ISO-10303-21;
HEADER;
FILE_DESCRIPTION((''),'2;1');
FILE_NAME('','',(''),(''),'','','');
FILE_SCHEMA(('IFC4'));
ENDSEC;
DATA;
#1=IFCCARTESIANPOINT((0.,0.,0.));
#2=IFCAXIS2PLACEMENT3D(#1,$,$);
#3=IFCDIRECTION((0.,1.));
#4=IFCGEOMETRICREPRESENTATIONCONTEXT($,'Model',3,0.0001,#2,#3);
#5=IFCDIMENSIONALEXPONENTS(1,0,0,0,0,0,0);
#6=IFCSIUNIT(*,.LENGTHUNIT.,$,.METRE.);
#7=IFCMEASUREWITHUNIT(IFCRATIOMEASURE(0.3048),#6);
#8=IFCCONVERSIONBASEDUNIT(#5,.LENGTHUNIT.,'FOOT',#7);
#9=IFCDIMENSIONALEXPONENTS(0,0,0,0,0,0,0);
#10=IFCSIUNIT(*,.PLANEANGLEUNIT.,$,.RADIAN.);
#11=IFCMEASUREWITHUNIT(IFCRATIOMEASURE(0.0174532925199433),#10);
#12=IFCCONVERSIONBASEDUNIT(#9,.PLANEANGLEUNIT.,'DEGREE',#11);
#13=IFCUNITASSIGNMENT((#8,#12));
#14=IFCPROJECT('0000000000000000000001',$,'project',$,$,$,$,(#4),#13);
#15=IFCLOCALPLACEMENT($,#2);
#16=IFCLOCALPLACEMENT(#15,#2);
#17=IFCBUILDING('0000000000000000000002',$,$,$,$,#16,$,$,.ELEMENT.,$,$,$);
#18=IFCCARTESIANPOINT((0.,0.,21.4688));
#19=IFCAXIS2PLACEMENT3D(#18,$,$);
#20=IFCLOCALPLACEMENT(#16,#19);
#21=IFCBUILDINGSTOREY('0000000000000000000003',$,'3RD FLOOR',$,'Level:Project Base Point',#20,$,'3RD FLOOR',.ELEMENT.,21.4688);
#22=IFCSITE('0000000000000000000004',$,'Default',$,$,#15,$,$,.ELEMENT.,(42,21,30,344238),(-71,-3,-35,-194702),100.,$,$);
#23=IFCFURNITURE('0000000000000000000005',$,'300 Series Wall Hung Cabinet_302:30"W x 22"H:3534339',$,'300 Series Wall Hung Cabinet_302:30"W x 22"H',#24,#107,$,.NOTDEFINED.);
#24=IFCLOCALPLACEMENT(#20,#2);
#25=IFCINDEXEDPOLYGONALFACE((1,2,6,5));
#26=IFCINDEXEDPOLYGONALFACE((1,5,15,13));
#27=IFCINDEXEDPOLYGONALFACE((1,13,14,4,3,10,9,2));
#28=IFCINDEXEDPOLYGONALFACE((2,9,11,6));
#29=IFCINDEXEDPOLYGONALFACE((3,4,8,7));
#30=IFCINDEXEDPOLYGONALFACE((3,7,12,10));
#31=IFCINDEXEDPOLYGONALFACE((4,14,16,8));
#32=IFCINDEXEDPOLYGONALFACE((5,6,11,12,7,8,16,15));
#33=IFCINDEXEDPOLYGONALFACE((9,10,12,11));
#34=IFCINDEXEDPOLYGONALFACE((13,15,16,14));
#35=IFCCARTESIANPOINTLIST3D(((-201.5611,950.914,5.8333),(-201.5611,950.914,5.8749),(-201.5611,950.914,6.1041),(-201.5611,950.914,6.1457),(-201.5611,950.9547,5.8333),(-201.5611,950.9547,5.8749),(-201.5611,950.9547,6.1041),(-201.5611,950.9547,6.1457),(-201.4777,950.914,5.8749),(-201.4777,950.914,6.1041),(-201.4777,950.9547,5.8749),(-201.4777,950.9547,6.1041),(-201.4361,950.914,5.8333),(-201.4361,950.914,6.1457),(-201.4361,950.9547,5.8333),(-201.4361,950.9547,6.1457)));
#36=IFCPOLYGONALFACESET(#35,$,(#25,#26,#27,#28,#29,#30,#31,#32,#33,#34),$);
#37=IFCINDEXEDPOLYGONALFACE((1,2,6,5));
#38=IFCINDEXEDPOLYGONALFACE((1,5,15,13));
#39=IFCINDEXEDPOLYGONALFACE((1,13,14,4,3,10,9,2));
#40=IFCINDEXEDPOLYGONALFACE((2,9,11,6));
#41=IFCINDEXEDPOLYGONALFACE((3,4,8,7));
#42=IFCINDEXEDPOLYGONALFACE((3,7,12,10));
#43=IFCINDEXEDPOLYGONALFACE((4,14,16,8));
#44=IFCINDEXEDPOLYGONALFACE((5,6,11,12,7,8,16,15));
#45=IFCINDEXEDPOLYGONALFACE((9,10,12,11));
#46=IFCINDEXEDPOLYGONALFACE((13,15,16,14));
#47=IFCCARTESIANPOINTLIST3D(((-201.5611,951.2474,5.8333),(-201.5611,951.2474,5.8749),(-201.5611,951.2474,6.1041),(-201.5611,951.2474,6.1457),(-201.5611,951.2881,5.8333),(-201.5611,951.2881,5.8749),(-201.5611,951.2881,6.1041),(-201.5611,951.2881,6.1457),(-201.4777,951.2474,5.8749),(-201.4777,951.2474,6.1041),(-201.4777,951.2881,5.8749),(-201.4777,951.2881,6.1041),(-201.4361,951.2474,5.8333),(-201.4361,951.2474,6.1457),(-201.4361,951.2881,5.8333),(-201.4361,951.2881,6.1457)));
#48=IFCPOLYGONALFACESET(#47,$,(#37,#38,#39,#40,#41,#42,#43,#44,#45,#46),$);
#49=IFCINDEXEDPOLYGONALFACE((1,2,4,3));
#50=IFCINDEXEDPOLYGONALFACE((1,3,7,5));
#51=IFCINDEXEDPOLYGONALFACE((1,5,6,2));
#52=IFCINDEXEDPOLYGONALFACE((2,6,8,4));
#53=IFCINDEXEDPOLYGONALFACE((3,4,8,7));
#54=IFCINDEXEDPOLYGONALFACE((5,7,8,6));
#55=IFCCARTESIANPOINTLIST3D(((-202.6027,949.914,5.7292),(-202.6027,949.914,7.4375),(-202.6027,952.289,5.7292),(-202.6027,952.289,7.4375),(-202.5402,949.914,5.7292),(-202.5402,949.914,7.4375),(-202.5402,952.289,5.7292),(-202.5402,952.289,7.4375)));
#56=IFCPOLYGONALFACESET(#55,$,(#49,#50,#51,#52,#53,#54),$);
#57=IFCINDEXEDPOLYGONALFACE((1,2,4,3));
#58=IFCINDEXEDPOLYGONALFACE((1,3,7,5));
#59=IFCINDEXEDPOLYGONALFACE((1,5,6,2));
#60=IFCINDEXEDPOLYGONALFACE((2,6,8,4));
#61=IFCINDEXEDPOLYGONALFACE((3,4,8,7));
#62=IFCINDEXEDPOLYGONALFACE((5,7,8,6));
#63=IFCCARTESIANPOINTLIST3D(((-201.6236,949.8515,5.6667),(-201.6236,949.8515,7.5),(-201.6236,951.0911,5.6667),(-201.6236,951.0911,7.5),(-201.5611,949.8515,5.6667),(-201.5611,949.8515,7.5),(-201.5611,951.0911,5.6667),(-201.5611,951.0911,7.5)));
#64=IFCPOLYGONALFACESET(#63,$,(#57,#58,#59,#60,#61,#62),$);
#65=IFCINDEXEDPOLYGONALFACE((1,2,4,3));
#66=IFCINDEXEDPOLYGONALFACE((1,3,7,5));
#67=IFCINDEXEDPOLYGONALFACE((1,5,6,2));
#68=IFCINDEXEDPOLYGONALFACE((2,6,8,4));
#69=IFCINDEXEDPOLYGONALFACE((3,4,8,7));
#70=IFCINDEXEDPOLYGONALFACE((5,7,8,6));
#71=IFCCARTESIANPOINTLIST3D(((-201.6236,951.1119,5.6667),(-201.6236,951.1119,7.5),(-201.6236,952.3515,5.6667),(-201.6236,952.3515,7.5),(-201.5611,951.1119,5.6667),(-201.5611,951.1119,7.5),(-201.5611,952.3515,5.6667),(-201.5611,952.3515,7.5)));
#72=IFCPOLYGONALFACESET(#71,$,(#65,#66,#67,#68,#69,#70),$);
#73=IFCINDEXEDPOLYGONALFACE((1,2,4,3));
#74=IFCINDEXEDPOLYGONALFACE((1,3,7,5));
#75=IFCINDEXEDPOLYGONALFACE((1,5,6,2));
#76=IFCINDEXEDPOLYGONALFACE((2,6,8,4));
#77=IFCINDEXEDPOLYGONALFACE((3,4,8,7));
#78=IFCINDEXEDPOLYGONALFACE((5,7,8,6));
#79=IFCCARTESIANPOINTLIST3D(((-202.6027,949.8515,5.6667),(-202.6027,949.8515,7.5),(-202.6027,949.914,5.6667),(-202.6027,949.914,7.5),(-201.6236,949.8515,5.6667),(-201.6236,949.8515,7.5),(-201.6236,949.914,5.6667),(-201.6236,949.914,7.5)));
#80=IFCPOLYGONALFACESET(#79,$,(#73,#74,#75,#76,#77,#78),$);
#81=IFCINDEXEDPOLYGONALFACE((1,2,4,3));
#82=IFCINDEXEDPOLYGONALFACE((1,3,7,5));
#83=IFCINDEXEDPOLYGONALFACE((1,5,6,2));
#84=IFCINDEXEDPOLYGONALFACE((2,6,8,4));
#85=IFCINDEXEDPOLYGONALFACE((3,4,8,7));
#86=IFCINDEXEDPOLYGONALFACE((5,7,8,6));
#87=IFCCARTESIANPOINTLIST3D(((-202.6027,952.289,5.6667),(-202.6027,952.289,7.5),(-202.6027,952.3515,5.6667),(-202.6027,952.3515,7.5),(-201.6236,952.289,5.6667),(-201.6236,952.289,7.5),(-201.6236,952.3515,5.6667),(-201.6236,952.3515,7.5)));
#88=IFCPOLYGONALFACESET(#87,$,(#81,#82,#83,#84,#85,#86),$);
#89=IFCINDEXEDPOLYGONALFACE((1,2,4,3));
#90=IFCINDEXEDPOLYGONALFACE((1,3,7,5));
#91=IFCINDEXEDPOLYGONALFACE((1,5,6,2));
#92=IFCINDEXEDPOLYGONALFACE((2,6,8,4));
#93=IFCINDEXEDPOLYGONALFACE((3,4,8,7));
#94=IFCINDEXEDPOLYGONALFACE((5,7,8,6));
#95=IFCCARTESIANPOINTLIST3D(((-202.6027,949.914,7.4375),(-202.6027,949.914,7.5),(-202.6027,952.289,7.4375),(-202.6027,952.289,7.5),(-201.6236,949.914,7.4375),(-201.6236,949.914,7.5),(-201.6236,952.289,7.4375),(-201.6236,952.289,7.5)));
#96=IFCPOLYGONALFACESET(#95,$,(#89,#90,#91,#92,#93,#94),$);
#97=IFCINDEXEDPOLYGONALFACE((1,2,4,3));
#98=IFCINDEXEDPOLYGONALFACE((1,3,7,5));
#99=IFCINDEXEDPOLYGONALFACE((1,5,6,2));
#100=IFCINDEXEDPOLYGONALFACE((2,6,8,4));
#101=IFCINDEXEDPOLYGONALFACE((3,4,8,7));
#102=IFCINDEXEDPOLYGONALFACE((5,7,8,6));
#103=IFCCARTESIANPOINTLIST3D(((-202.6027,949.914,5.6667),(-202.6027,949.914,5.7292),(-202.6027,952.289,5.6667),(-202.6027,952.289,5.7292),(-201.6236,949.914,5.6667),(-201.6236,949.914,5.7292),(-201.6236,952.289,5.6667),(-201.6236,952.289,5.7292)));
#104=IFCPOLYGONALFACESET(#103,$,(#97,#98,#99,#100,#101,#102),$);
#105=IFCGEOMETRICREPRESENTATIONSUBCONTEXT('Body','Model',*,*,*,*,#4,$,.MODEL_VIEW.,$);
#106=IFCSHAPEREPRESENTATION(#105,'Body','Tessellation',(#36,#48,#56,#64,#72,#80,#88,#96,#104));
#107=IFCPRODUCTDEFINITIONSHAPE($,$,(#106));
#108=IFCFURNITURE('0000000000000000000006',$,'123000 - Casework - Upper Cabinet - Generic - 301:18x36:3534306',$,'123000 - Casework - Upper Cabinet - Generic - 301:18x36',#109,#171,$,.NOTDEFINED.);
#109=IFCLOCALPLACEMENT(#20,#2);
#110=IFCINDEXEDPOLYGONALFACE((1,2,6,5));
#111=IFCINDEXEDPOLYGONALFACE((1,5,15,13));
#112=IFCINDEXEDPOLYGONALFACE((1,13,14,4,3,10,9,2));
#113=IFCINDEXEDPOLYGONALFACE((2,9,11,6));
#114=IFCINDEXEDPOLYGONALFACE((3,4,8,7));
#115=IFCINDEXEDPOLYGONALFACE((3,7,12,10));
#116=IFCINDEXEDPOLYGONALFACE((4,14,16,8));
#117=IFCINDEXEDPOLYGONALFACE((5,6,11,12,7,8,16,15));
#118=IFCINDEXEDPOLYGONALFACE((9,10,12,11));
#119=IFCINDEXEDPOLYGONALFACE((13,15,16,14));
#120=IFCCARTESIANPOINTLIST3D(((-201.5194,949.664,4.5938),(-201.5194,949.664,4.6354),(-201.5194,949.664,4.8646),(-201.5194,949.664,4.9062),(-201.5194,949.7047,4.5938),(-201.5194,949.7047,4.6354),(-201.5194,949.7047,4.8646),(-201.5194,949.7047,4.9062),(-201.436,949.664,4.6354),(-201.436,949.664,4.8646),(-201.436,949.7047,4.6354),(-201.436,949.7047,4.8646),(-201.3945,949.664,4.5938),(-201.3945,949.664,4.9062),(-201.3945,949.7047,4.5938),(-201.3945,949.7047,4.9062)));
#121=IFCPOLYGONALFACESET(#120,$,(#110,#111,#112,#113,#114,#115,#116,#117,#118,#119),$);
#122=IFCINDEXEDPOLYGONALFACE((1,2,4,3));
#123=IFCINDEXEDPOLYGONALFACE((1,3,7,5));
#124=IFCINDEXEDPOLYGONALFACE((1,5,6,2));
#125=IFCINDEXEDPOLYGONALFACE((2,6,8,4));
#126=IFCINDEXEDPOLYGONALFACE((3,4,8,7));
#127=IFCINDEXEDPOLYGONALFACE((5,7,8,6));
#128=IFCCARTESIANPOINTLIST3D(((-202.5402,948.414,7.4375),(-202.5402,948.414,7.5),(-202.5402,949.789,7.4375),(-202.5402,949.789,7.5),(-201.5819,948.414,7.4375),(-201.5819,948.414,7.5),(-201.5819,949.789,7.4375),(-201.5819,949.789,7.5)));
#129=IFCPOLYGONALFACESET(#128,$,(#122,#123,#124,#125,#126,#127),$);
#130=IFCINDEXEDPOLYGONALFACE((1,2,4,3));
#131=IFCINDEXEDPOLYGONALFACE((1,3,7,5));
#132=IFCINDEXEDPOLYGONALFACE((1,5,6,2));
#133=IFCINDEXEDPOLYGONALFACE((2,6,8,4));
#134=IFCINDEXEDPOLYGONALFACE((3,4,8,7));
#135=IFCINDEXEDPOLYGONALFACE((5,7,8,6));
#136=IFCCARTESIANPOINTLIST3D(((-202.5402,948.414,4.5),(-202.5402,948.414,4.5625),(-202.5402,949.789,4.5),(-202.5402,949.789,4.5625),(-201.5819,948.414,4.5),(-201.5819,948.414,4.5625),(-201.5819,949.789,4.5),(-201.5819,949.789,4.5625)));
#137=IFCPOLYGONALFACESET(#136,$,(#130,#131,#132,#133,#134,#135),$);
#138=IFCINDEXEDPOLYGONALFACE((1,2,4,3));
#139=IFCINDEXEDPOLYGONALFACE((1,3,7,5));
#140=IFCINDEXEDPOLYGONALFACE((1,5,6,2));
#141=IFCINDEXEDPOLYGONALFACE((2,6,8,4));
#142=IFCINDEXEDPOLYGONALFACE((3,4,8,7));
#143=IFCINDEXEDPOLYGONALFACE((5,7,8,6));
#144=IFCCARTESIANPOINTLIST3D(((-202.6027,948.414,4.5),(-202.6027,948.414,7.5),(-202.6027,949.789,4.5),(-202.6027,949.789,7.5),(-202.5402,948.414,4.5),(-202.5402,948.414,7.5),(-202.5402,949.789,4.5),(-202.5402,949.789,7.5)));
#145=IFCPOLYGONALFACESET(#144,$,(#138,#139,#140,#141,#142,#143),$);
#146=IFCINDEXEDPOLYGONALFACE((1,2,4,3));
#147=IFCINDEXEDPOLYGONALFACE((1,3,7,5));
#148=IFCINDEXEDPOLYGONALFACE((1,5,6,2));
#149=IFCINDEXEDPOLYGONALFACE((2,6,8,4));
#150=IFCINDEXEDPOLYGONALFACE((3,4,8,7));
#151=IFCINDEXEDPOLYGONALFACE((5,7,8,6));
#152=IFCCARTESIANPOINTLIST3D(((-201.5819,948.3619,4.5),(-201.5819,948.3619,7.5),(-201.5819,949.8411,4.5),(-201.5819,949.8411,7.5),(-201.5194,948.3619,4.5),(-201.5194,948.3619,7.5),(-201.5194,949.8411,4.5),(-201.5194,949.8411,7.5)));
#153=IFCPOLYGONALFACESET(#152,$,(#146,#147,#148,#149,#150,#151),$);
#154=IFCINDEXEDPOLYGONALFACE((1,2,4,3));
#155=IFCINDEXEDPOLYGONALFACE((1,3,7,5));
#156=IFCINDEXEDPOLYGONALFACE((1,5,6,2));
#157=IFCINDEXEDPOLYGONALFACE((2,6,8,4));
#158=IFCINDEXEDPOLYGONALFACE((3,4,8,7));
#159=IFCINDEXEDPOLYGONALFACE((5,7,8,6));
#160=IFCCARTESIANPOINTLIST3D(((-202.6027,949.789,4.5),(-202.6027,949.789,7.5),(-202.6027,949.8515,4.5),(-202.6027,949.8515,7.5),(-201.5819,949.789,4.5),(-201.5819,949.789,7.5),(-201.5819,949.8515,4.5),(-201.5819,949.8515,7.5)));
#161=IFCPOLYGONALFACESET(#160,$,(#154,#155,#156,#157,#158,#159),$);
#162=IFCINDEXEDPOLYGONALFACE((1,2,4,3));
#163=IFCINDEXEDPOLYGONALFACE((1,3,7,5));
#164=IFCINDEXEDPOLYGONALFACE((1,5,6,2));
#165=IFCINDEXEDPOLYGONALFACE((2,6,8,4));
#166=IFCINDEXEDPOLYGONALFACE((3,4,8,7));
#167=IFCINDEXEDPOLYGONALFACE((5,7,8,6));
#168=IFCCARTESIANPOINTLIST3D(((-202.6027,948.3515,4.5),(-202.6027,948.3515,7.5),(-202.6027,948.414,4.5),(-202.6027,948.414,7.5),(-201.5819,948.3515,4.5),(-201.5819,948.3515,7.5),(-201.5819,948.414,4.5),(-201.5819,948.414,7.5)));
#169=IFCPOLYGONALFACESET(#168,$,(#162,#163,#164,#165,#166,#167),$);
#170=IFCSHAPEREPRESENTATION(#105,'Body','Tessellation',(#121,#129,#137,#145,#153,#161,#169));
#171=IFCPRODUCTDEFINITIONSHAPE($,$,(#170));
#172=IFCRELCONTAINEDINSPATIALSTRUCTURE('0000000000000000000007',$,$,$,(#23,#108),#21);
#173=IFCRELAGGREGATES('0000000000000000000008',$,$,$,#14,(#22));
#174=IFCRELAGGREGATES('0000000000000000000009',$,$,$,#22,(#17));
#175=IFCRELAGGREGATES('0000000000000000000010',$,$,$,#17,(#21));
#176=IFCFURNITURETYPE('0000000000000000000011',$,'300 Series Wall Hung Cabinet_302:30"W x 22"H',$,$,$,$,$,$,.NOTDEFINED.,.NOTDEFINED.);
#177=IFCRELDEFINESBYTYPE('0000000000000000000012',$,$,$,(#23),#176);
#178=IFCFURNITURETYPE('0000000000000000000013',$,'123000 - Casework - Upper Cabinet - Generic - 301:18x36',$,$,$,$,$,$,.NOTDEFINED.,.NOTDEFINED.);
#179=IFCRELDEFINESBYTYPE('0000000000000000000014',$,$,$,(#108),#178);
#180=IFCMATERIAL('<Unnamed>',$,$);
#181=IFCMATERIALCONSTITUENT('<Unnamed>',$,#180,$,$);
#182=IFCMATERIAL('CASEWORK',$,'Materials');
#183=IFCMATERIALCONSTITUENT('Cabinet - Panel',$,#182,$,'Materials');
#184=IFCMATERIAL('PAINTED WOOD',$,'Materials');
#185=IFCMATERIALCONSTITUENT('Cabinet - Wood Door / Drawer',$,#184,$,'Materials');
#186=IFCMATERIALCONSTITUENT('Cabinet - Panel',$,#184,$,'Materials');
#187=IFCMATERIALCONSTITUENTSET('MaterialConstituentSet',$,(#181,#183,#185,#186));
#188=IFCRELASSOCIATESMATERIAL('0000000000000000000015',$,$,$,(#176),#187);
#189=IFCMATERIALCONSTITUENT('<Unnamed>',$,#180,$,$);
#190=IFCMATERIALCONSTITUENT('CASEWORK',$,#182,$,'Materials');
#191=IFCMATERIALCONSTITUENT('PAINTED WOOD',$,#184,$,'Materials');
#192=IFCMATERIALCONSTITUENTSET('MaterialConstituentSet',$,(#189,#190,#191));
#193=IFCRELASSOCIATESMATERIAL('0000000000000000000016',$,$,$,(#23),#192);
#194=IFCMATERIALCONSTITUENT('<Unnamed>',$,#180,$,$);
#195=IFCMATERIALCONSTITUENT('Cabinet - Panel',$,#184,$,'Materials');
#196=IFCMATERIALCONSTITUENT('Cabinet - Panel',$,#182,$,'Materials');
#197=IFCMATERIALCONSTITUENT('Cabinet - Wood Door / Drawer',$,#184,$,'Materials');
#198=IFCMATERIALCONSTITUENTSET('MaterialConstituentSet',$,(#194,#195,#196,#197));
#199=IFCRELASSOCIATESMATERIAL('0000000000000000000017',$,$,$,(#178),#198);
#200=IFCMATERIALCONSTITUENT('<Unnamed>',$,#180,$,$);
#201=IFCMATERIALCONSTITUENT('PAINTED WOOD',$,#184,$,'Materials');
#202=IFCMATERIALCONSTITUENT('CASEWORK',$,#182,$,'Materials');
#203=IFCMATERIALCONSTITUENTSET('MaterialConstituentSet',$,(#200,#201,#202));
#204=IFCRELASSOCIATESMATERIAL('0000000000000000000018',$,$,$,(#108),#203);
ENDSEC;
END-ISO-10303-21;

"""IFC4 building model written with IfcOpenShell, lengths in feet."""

from ifc_helpers import new_model, entity, si_unit, converted_unit, direction, frame, frame_2d, origin, origin_2d_with_axis, place, context, subcontext, project, spatial, polyline, rectangle, outline, extrude, source, transform, mapped, material, constituent, constituent_set, type_object, type_shapes, element, save


model = new_model("IFC4")

# Units and contexts
model_context = context("Model", 3, precision=0.0001, world=origin(), true_north=direction((0.0, 1.0)))
body_context = subcontext(model_context, "Body", "Model", "MODEL_VIEW")
ifc_project = project(units=[converted_unit("LENGTHUNIT", "FOOT", entity("IfcRatioMeasure", 0.3048), si_unit("LENGTHUNIT", "METRE"), dimensions=[1, 0, 0, 0, 0, 0, 0]), converted_unit("PLANEANGLEUNIT", "DEGREE", entity("IfcRatioMeasure", 0.0174532925199433), si_unit("PLANEANGLEUNIT", "RADIAN"), dimensions=[0, 0, 0, 0, 0, 0, 0])], contexts=[model_context])

# Site, building, storey
site_placement = place(None, origin())
site = spatial("IfcSite", under=ifc_project, at=site_placement, Name="Default", CompositionType="ELEMENT", RefLatitude=(42, 21, 30, 344238), RefLongitude=(-71, -3, -35, -194702), RefElevation=100.0)
building_placement = place(site_placement, origin())
building = spatial("IfcBuilding", under=site, at=building_placement, CompositionType="ELEMENT")
storey_placement = place(building_placement, frame((0.0, 0.0, 21.4688)))
storey = spatial("IfcBuildingStorey", under=building, at=storey_placement, Name="3RD FLOOR", ObjectType="Level:Project Base Point", LongName="3RD FLOOR", CompositionType="ELEMENT", Elevation=21.4688)

# Furniture
ifc_material_1 = material(Name="PAINTED WOOD", Category="Materials")
ifc_material_2 = material(Name="CASEWORK", Category="Materials")
ifc_material_3 = material(Name="<Unnamed>")
ifc_constituent_1 = constituent(ifc_material_3, Name="<Unnamed>")
ifc_constituent_2 = constituent(ifc_material_2, Name="CASEWORK", Category="Materials")
ifc_constituent_3 = constituent(ifc_material_1, Name="PAINTED WOOD", Category="Materials")
ifc_constituent_set_1 = constituent_set(constituents=[ifc_constituent_1, ifc_constituent_2, ifc_constituent_3], Name="MaterialConstituentSet")
ifc_constituent_4 = constituent(ifc_material_3, Name="<Unnamed>")
ifc_constituent_5 = constituent(ifc_material_2, Name="Cabinet - Panel", Category="Materials")
ifc_constituent_6 = constituent(ifc_material_1, Name="Cabinet - Wood Door / Drawer", Category="Materials")
ifc_constituent_7 = constituent(ifc_material_1, Name="Cabinet - Panel", Category="Materials")
ifc_constituent_set_2 = constituent_set(constituents=[ifc_constituent_4, ifc_constituent_5, ifc_constituent_6, ifc_constituent_7], Name="MaterialConstituentSet")
furniture_type_1 = type_object("IfcFurnitureType", Name="300 Series Wall Hung Cabinet_302:30\"W x 22\"H", AssemblyPlace="NOTDEFINED", PredefinedType="NOTDEFINED", material=ifc_constituent_set_2)
shared_shape_1 = source(origin(), body_context, "Body", "SweptSolid", [
    extrude(outline(polyline([(0.1146, -0.0521), (0.1562, -0.0521), (0.1562, 0.0729), (-0.1562, 0.0729), (-0.1562, -0.0521), (-0.1146, -0.0521), (-0.1146, 0.0313), (0.1146, 0.0313), (0.1146, -0.0521)])), frame((1.0625, 0.0729, 0.3229), z_axis=(1.0, 0.0, 0.0), x_axis=(0.0, 0.0, 1.0)), (0.0, 0.0, 1.0), 0.0407),
    extrude(outline(polyline([(0.1146, -0.0521), (0.1562, -0.0521), (0.1562, 0.0729), (-0.1562, 0.0729), (-0.1562, -0.0521), (-0.1146, -0.0521), (-0.1146, 0.0313), (0.1146, 0.0313), (0.1146, -0.0521)])), frame((1.3958, 0.0729, 0.3229), z_axis=(1.0, 0.0, 0.0), x_axis=(0.0, 0.0, 1.0)), (0.0, 0.0, 1.0), 0.0407),
    extrude(rectangle(XDim=2.375, YDim=0.0625, at=origin_2d_with_axis()), frame((1.25, 1.1354, 0.0625), z_axis=(0.0, 0.0, 1.0), x_axis=(-1.0, 0.0, 0.0)), (0.0, 0.0, 1.0), 1.7083),
    extrude(rectangle(XDim=1.2396, YDim=0.0625, at=origin_2d_with_axis()), frame((0.6198, 0.1562, 0.0), z_axis=(0.0, 0.0, 1.0), x_axis=(-1.0, 0.0, 0.0)), (0.0, 0.0, 1.0), 1.8333),
    extrude(rectangle(XDim=1.2396, YDim=0.0625, at=frame_2d((0.0, 0.0), x_axis=(1.0, 0.0))), frame((1.8802, 0.1562, 0.0), z_axis=(0.0, 0.0, 1.0), x_axis=(-1.0, 0.0, 0.0)), (0.0, 0.0, 1.0), 1.8333),
    extrude(rectangle(XDim=0.9792, YDim=0.0625, at=frame_2d((0.0, 0.0), x_axis=(1.0, 0.0))), frame((0.0313, 0.677, 0.0), z_axis=(0.0, 0.0, 1.0), x_axis=(0.0, -1.0, 0.0)), (0.0, 0.0, 1.0), 1.8333),
    extrude(rectangle(XDim=0.9792, YDim=0.0625, at=frame_2d((0.0, 0.0), x_axis=(1.0, 0.0))), frame((2.4688, 0.677, 0.0), z_axis=(0.0, 0.0, 1.0), x_axis=(0.0, -1.0, 0.0)), (0.0, 0.0, 1.0), 1.8333),
    extrude(rectangle(XDim=0.9792, YDim=2.375, at=frame_2d((0.0, 0.0), x_axis=(1.0, 0.0))), frame((1.25, 0.677, 1.7708), z_axis=(0.0, 0.0, 1.0), x_axis=(0.0, 1.0, 0.0)), (0.0, 0.0, 1.0), 0.0625),
    extrude(rectangle(XDim=0.9792, YDim=2.375, at=frame_2d((0.0, 0.0), x_axis=(1.0, 0.0))), frame((1.25, 0.677, 0.0), z_axis=(0.0, 0.0, 1.0), x_axis=(0.0, 1.0, 0.0)), (0.0, 0.0, 1.0), 0.0625),
])
type_shapes(furniture_type_1, [shared_shape_1])
furniture_1_placement = place(storey_placement, frame((-201.4361, 949.8515, 5.6667), z_axis=(0.0, 0.0, 1.0), x_axis=(0.0, 1.0, 0.0)))
element("IfcFurniture", 1, at=furniture_1_placement, inside=storey, type_object=furniture_type_1, material=ifc_constituent_set_1, Name="300 Series Wall Hung Cabinet_302:30\"W x 22\"H:3534339", ObjectType="300 Series Wall Hung Cabinet_302:30\"W x 22\"H", PredefinedType="NOTDEFINED", context=body_context, shape_type="MappedRepresentation", body=[
    mapped(shared_shape_1, transform((0.0, 0.0, 0.0), scale=1.0)),
])
ifc_constituent_8 = constituent(ifc_material_3, Name="<Unnamed>")
ifc_constituent_9 = constituent(ifc_material_1, Name="PAINTED WOOD", Category="Materials")
ifc_constituent_10 = constituent(ifc_material_2, Name="CASEWORK", Category="Materials")
ifc_constituent_set_3 = constituent_set(constituents=[ifc_constituent_8, ifc_constituent_9, ifc_constituent_10], Name="MaterialConstituentSet")
ifc_constituent_11 = constituent(ifc_material_3, Name="<Unnamed>")
ifc_constituent_12 = constituent(ifc_material_1, Name="Cabinet - Panel", Category="Materials")
ifc_constituent_13 = constituent(ifc_material_2, Name="Cabinet - Panel", Category="Materials")
ifc_constituent_14 = constituent(ifc_material_1, Name="Cabinet - Wood Door / Drawer", Category="Materials")
ifc_constituent_set_4 = constituent_set(constituents=[ifc_constituent_11, ifc_constituent_12, ifc_constituent_13, ifc_constituent_14], Name="MaterialConstituentSet")
furniture_type_2 = type_object("IfcFurnitureType", Name="123000 - Casework - Upper Cabinet - Generic - 301:18x36", AssemblyPlace="NOTDEFINED", PredefinedType="NOTDEFINED", material=ifc_constituent_set_4)
shared_shape_2 = source(origin(), body_context, "Body", "SweptSolid", [
    extrude(outline(polyline([(-0.0521, -0.1146), (-0.0521, -0.1562), (0.0729, -0.1562), (0.0729, 0.1562), (-0.0521, 0.1562), (-0.0521, 0.1146), (0.0313, 0.1146), (0.0313, -0.1146), (-0.0521, -0.1146)])), frame((0.1468, 1.1354, 0.25), z_axis=(-1.0, 0.0, 0.0), x_axis=(0.0, 1.0, 0.0)), (0.0, 0.0, -1.0), 0.0407),
    extrude(rectangle(XDim=0.9583, YDim=1.375, at=frame_2d((0.0, 0.0), x_axis=(1.0, 0.0))), frame((0.75, 0.5417, 2.9375), z_axis=(0.0, 0.0, 1.0), x_axis=(0.0, 1.0, 0.0)), (0.0, 0.0, 1.0), 0.0625),
    extrude(rectangle(XDim=0.9583, YDim=1.375, at=frame_2d((0.0, 0.0), x_axis=(1.0, 0.0))), frame((0.75, 0.5417, 0.0), z_axis=(0.0, 0.0, 1.0), x_axis=(0.0, 1.0, 0.0)), (0.0, 0.0, 1.0), 0.0625),
    extrude(rectangle(XDim=1.375, YDim=0.0625, at=origin_2d_with_axis()), frame((0.75, 0.0313, 0.0), z_axis=(0.0, 0.0, 1.0), x_axis=(-1.0, 0.0, 0.0)), (0.0, 0.0, 1.0), 3.0),
    extrude(rectangle(XDim=1.4792, YDim=0.0625, at=origin_2d_with_axis()), frame((0.75, 1.0521, 0.0)), (0.0, 0.0, 1.0), 3.0),
    extrude(rectangle(XDim=1.0208, YDim=0.0625, at=origin_2d_with_axis()), frame((0.0312, 0.5104, 0.0), z_axis=(0.0, 0.0, 1.0), x_axis=(0.0, 1.0, 0.0)), (0.0, 0.0, 1.0), 3.0),
    extrude(rectangle(XDim=1.0208, YDim=0.0625, at=origin_2d_with_axis()), frame((1.4688, 0.5104, 0.0), z_axis=(0.0, 0.0, 1.0), x_axis=(0.0, 1.0, 0.0)), (0.0, 0.0, 1.0), 3.0),
])
type_shapes(furniture_type_2, [shared_shape_2])
furniture_2_placement = place(storey_placement, frame((-202.6027, 949.8515, 4.5), z_axis=(0.0, 0.0, 1.0), x_axis=(0.0, -1.0, 0.0)))
element("IfcFurniture", 2, at=furniture_2_placement, inside=storey, type_object=furniture_type_2, material=ifc_constituent_set_3, Name="123000 - Casework - Upper Cabinet - Generic - 301:18x36:3534306", ObjectType="123000 - Casework - Upper Cabinet - Generic - 301:18x36", PredefinedType="NOTDEFINED", context=body_context, shape_type="MappedRepresentation", body=[
    mapped(shared_shape_2, transform((0.0, 0.0, 0.0), scale=1.0)),
])

save(model, "model.ifc")
